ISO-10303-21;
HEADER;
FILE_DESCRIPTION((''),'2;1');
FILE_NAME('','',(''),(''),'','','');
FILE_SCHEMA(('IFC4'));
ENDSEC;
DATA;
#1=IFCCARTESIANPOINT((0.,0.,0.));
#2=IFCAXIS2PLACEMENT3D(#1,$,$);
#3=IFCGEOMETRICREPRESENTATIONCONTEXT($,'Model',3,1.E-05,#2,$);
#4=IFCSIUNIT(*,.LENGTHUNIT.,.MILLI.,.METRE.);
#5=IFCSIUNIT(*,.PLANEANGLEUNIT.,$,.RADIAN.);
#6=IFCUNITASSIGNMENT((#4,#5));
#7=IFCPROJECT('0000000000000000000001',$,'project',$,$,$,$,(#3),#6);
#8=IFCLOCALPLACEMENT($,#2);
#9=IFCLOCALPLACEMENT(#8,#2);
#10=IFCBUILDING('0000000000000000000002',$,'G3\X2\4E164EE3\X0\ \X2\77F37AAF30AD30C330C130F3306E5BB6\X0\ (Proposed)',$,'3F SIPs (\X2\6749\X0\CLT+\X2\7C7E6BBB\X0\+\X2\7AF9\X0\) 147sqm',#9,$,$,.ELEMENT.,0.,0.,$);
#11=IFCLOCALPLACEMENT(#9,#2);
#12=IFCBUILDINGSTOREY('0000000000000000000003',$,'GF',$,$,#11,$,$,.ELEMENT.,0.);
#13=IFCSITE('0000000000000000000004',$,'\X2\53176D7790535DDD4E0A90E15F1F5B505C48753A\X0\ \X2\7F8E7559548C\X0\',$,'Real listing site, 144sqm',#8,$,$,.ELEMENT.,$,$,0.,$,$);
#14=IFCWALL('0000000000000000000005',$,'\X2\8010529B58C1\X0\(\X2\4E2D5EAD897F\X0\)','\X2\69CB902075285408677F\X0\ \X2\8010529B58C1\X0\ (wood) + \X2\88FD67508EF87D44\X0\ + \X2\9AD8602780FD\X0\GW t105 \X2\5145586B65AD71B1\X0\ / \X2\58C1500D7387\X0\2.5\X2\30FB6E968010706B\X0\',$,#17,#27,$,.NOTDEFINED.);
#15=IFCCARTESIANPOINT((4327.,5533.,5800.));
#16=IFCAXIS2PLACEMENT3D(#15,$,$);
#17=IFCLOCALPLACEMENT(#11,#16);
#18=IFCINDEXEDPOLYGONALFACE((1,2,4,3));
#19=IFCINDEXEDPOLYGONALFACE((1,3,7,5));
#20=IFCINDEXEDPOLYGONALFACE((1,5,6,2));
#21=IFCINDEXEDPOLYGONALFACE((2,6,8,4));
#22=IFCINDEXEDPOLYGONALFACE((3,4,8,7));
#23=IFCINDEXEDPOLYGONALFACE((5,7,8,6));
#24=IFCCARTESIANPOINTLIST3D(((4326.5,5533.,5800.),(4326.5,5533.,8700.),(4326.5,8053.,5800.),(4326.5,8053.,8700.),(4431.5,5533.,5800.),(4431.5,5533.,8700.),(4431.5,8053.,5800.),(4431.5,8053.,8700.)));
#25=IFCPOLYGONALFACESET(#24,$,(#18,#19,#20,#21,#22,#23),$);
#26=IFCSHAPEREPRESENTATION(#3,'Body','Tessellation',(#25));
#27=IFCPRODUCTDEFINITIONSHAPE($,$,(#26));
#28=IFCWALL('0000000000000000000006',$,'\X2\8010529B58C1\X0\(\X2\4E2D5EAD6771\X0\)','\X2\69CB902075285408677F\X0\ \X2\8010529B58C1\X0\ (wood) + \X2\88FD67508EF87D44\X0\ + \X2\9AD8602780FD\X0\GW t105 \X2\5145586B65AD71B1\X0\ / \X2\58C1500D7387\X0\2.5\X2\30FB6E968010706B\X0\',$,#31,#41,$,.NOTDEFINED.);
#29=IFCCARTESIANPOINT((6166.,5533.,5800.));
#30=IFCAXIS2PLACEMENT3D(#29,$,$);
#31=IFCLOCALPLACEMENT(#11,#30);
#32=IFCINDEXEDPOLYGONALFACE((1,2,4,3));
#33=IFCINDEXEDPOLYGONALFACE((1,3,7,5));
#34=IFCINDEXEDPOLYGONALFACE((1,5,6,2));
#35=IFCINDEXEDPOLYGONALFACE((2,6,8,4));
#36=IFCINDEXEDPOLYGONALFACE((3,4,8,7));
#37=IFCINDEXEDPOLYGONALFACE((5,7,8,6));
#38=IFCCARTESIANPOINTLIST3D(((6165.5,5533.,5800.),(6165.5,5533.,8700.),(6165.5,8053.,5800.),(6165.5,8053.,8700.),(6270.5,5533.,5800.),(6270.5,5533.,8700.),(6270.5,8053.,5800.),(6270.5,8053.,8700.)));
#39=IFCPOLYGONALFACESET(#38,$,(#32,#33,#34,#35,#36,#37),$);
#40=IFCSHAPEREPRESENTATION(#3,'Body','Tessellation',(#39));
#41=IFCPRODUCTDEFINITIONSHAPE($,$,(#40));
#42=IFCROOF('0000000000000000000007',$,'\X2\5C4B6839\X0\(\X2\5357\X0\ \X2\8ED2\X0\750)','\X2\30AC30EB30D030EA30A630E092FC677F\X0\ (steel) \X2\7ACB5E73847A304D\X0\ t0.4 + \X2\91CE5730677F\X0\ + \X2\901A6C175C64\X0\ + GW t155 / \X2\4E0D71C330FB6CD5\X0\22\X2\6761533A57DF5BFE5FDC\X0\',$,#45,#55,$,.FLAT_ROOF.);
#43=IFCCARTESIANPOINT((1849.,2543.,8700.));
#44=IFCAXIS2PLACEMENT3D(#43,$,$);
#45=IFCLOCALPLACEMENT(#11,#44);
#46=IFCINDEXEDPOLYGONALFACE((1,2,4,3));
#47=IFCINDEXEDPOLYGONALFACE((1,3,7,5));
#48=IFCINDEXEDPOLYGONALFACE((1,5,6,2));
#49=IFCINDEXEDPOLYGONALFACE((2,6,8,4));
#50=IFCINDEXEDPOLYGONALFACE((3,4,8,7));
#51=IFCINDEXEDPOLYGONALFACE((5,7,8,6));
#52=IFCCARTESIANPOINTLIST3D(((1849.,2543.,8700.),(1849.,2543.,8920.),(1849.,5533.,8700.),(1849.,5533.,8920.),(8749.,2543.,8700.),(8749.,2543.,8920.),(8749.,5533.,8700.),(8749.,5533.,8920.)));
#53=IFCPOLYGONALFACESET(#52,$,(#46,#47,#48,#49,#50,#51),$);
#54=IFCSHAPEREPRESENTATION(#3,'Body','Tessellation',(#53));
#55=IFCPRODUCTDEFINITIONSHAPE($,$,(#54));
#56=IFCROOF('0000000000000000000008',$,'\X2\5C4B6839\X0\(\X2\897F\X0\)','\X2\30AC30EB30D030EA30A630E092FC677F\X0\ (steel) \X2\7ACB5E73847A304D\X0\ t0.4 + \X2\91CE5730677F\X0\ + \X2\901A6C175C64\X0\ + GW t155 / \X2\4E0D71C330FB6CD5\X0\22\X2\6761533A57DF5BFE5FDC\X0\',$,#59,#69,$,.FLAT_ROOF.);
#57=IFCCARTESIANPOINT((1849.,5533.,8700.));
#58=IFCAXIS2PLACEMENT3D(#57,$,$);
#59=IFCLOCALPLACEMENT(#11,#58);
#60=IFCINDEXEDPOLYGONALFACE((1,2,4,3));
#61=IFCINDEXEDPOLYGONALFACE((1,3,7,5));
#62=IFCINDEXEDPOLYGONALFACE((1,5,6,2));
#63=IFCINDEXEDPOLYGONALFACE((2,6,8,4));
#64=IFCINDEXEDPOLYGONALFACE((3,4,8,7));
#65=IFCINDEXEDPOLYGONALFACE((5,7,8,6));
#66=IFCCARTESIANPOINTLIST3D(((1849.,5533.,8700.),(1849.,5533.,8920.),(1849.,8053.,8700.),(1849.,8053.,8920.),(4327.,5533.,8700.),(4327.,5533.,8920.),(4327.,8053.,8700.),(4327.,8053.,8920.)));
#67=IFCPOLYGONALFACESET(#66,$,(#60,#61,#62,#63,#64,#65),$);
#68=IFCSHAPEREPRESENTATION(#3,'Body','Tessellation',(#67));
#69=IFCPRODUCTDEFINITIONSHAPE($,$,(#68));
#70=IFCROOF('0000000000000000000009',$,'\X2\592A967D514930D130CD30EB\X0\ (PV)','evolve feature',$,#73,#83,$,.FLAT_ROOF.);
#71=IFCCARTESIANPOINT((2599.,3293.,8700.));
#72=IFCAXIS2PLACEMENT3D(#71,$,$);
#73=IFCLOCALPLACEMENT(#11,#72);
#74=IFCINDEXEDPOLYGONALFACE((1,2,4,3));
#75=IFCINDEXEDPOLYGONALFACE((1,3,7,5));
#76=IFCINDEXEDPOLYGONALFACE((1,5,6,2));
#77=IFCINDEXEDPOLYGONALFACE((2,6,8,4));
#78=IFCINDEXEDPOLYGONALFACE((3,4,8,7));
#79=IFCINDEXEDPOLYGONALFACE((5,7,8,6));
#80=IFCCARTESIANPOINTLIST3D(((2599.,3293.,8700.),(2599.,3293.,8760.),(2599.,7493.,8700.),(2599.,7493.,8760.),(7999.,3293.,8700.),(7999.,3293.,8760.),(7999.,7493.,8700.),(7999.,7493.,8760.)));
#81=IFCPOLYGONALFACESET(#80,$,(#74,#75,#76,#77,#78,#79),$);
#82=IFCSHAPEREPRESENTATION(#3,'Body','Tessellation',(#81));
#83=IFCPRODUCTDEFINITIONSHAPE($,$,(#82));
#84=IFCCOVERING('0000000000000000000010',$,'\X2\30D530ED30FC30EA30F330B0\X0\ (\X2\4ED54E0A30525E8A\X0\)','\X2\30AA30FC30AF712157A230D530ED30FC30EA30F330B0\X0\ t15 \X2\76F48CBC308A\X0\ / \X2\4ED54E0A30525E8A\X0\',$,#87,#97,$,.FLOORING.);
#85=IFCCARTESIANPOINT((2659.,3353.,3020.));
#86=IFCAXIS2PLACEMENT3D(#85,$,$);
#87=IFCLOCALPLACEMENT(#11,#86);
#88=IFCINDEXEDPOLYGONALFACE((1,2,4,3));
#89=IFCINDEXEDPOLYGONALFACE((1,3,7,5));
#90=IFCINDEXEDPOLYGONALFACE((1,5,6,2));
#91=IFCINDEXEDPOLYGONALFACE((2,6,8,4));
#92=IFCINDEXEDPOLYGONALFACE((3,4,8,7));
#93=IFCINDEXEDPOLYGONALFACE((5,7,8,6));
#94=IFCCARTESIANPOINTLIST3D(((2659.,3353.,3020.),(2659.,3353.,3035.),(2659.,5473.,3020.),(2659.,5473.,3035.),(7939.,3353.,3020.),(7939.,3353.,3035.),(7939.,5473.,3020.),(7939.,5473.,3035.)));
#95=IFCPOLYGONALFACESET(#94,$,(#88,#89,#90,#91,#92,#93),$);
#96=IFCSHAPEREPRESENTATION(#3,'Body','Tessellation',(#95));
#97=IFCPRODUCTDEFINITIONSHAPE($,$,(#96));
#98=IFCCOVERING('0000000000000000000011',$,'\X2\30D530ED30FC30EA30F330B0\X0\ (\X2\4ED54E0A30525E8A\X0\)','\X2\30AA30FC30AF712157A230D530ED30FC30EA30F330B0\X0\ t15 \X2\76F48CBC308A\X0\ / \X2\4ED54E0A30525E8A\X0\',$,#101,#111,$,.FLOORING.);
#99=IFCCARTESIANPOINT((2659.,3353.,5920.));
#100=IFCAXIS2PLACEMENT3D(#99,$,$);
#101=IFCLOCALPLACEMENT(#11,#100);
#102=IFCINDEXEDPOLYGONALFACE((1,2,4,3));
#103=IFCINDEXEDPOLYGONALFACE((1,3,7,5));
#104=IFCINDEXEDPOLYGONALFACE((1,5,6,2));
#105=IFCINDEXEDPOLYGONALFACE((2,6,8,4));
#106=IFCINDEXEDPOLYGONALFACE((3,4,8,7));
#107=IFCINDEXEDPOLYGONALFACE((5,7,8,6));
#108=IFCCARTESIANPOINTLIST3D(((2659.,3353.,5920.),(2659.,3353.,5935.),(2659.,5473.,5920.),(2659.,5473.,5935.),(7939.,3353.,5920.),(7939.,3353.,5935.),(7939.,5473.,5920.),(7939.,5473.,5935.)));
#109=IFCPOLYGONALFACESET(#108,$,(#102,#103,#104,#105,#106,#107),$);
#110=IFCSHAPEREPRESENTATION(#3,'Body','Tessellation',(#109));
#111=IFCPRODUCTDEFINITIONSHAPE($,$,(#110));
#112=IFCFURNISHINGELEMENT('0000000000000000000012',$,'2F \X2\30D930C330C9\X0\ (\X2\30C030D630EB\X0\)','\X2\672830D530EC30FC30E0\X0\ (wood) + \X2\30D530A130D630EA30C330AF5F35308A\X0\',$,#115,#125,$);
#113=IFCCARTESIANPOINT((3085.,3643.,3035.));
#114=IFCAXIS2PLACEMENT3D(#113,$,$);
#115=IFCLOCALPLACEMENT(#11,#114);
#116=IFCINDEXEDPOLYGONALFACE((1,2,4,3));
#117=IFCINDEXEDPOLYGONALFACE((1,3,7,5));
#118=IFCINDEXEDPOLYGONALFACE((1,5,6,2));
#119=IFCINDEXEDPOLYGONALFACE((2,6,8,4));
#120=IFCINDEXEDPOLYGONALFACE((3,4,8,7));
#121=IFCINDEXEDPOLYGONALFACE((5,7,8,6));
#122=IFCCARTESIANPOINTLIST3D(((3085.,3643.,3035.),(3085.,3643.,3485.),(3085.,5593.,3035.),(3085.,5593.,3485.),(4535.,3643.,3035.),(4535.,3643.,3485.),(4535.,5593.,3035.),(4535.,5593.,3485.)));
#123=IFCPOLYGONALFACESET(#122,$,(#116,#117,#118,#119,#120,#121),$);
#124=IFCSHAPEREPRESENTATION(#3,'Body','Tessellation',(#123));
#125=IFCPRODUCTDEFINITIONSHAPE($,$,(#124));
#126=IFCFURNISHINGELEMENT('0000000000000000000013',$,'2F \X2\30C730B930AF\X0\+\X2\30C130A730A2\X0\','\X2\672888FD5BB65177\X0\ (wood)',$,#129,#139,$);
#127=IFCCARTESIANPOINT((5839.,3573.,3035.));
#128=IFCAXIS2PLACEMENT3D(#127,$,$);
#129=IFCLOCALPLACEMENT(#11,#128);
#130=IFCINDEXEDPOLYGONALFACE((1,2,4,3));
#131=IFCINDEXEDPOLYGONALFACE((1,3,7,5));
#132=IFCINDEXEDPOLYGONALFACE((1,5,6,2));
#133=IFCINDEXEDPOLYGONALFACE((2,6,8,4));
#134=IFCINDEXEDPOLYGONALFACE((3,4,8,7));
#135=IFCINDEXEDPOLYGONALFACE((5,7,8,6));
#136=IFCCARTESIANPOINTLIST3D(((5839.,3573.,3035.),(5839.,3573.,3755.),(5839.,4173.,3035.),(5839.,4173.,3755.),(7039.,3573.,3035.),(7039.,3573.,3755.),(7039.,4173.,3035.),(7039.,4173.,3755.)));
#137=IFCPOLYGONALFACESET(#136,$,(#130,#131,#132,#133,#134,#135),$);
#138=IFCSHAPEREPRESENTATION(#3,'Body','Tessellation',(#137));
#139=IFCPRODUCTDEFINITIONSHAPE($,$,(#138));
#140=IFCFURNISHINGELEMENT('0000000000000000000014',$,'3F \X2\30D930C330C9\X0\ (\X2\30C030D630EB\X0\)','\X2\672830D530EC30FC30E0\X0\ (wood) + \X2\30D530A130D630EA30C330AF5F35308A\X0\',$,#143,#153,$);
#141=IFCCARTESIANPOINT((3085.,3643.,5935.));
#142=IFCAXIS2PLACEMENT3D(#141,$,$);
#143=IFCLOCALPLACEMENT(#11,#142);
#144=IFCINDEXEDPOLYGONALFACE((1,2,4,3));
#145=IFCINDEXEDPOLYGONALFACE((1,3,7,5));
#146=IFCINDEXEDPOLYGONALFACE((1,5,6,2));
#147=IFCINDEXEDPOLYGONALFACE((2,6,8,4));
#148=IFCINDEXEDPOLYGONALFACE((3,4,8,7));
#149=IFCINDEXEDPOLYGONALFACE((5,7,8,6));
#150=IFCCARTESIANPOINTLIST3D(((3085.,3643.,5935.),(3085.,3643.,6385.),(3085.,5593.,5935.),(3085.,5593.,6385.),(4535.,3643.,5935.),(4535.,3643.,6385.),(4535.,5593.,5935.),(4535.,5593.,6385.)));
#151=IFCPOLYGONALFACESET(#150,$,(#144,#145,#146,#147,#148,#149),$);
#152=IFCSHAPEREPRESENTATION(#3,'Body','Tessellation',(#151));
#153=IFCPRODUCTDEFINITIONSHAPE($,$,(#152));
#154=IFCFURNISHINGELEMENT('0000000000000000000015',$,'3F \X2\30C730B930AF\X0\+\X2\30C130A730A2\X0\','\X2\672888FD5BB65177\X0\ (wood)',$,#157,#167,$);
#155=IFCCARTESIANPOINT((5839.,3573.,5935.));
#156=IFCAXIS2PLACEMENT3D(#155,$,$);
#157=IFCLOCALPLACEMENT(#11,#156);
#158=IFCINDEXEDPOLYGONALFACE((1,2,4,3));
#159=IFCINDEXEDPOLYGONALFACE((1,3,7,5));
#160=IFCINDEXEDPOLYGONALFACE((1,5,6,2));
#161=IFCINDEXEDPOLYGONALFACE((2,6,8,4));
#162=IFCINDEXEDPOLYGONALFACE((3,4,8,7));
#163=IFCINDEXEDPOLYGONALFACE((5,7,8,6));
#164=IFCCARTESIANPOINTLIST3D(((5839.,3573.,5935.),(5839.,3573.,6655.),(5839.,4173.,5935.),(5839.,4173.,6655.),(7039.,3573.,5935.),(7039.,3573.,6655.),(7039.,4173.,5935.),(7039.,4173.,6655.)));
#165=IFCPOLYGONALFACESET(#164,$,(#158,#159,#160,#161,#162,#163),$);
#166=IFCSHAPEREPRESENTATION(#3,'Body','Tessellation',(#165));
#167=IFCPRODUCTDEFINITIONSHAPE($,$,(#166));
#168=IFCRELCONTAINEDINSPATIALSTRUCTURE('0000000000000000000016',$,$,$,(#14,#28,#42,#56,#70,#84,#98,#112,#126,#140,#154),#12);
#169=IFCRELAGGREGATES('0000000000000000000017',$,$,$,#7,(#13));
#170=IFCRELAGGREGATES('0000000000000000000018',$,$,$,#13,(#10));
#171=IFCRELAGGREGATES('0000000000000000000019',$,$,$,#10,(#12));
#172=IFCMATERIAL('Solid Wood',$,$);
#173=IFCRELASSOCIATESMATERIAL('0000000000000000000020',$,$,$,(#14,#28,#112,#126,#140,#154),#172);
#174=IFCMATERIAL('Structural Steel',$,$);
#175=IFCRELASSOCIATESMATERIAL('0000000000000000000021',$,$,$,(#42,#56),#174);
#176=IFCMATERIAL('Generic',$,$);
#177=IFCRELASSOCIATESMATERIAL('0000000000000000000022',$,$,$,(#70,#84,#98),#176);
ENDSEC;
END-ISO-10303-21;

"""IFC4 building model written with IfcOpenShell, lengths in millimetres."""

from ifc_helpers import new_model, si_unit, frame, frame_2d, origin, place, context, project, spatial, rectangle, extrude, material, element, save


model = new_model("IFC4")

# Units and contexts
model_context = context("Model", 3, precision=1e-05, world=origin())
ifc_project = project(units=[si_unit("LENGTHUNIT", "METRE", prefix="MILLI"), si_unit("PLANEANGLEUNIT", "RADIAN")], contexts=[model_context])

# Site, building, storey
site_placement = place(None, origin())
site = spatial("IfcSite", under=ifc_project, at=site_placement, Name="北海道川上郡弟子屈町 美留和", ObjectType="Real listing site, 144sqm", CompositionType="ELEMENT", RefElevation=0.0)
building_placement = place(site_placement, origin())
building = spatial("IfcBuilding", under=site, at=building_placement, Name="G3世代 石窯キッチンの家 (Proposed)", ObjectType="3F SIPs (杉CLT+籾殻+竹) 147sqm", CompositionType="ELEMENT", ElevationOfRefHeight=0.0, ElevationOfTerrain=0.0)
storey_placement = place(building_placement, origin())
storey = spatial("IfcBuildingStorey", under=building, at=storey_placement, Name="GF", CompositionType="ELEMENT", Elevation=0.0)

# Shared definitions
ifc_material_1 = material(Name="Solid Wood")

# Walls
wall_1_placement = place(storey_placement, frame((4327.0, 5533.0, 5800.0)))
element("IfcWall", 1, at=wall_1_placement, inside=storey, material=ifc_material_1, Name="耐力壁(中庭西)", Description="構造用合板 耐力壁 (wood) + 製材軸組 + 高性能GW t105 充填断熱 / 壁倍率2.5・準耐火", PredefinedType="NOTDEFINED", context=model_context, shape_type="SweptSolid", body=[
    extrude(rectangle(XDim=105.0, YDim=2520.0, at=frame_2d((52.0, 1260.0))), frame((4327.0, 5533.0, 5800.0)), (0.0, 0.0, 1.0), 2900.0),
])
wall_2_placement = place(storey_placement, frame((6166.0, 5533.0, 5800.0)))
element("IfcWall", 2, at=wall_2_placement, inside=storey, material=ifc_material_1, Name="耐力壁(中庭東)", Description="構造用合板 耐力壁 (wood) + 製材軸組 + 高性能GW t105 充填断熱 / 壁倍率2.5・準耐火", PredefinedType="NOTDEFINED", context=model_context, shape_type="SweptSolid", body=[
    extrude(rectangle(XDim=105.0, YDim=2520.0, at=frame_2d((52.0, 1260.0))), frame((6166.0, 5533.0, 5800.0)), (0.0, 0.0, 1.0), 2900.0),
])

# Roofs
ifc_material_2 = material(Name="Structural Steel")
roof_1_placement = place(storey_placement, frame((1849.0, 2543.0, 8700.0)))
element("IfcRoof", 3, at=roof_1_placement, inside=storey, material=ifc_material_2, Name="屋根(南 軒750)", Description="ガルバリウム鋼板 (steel) 立平葺き t0.4 + 野地板 + 通気層 + GW t155 / 不燃・法22条区域対応", PredefinedType="FLAT_ROOF", context=model_context, shape_type="SweptSolid", body=[
    extrude(rectangle(XDim=6900.0, YDim=2990.0, at=frame_2d((3450.0, 1495.0))), frame((1849.0, 2543.0, 8700.0)), (0.0, 0.0, 1.0), 220.0),
])
roof_2_placement = place(storey_placement, frame((1849.0, 5533.0, 8700.0)))
element("IfcRoof", 4, at=roof_2_placement, inside=storey, material=ifc_material_2, Name="屋根(西)", Description="ガルバリウム鋼板 (steel) 立平葺き t0.4 + 野地板 + 通気層 + GW t155 / 不燃・法22条区域対応", PredefinedType="FLAT_ROOF", context=model_context, shape_type="SweptSolid", body=[
    extrude(rectangle(XDim=2478.0, YDim=2520.0, at=frame_2d((1239.0, 1260.0))), frame((1849.0, 5533.0, 8700.0)), (0.0, 0.0, 1.0), 220.0),
])
ifc_material_3 = material(Name="Generic")
roof_3_placement = place(storey_placement, frame((2599.0, 3293.0, 8700.0)))
element("IfcRoof", 5, at=roof_3_placement, inside=storey, material=ifc_material_3, Name="太陽光パネル (PV)", Description="evolve feature", PredefinedType="FLAT_ROOF", context=model_context, shape_type="SweptSolid", body=[
    extrude(rectangle(XDim=5400.0, YDim=4200.0, at=frame_2d((2700.0, 2100.0))), frame((2599.0, 3293.0, 8700.0)), (0.0, 0.0, 1.0), 60.0),
])

# Coverings
covering_1_placement = place(storey_placement, frame((2659.0, 3353.0, 3020.0)))
element("IfcCovering", 6, at=covering_1_placement, inside=storey, material=ifc_material_3, Name="フローリング (仕上げ床)", Description="オーク無垢フローリング t15 直貼り / 仕上げ床", PredefinedType="FLOORING", context=model_context, shape_type="SweptSolid", body=[
    extrude(rectangle(XDim=5280.0, YDim=2120.0, at=frame_2d((2640.0, 1060.0))), frame((2659.0, 3353.0, 3020.0)), (0.0, 0.0, 1.0), 15.0),
])
covering_2_placement = place(storey_placement, frame((2659.0, 3353.0, 5920.0)))
element("IfcCovering", 7, at=covering_2_placement, inside=storey, material=ifc_material_3, Name="フローリング (仕上げ床)", Description="オーク無垢フローリング t15 直貼り / 仕上げ床", PredefinedType="FLOORING", context=model_context, shape_type="SweptSolid", body=[
    extrude(rectangle(XDim=5280.0, YDim=2120.0, at=frame_2d((2640.0, 1060.0))), frame((2659.0, 3353.0, 5920.0)), (0.0, 0.0, 1.0), 15.0),
])

# Furnishing elements
furnishing_1_placement = place(storey_placement, frame((3085.0, 3643.0, 3035.0)))
element("IfcFurnishingElement", 8, at=furnishing_1_placement, inside=storey, material=ifc_material_1, Name="2F ベッド (ダブル)", Description="木フレーム (wood) + ファブリック張り", context=model_context, shape_type="SweptSolid", body=[
    extrude(rectangle(XDim=1450.0, YDim=1950.0, at=frame_2d((725.0, 975.0))), frame((3085.0, 3643.0, 3035.0)), (0.0, 0.0, 1.0), 450.0),
])
furnishing_2_placement = place(storey_placement, frame((5839.0, 3573.0, 3035.0)))
element("IfcFurnishingElement", 9, at=furnishing_2_placement, inside=storey, material=ifc_material_1, Name="2F デスク+チェア", Description="木製家具 (wood)", context=model_context, shape_type="SweptSolid", body=[
    extrude(rectangle(XDim=1200.0, YDim=600.0, at=frame_2d((600.0, 300.0))), frame((5839.0, 3573.0, 3035.0)), (0.0, 0.0, 1.0), 720.0),
])
furnishing_3_placement = place(storey_placement, frame((3085.0, 3643.0, 5935.0)))
element("IfcFurnishingElement", 10, at=furnishing_3_placement, inside=storey, material=ifc_material_1, Name="3F ベッド (ダブル)", Description="木フレーム (wood) + ファブリック張り", context=model_context, shape_type="SweptSolid", body=[
    extrude(rectangle(XDim=1450.0, YDim=1950.0, at=frame_2d((725.0, 975.0))), frame((3085.0, 3643.0, 5935.0)), (0.0, 0.0, 1.0), 450.0),
])
furnishing_4_placement = place(storey_placement, frame((5839.0, 3573.0, 5935.0)))
element("IfcFurnishingElement", 11, at=furnishing_4_placement, inside=storey, material=ifc_material_1, Name="3F デスク+チェア", Description="木製家具 (wood)", context=model_context, shape_type="SweptSolid", body=[
    extrude(rectangle(XDim=1200.0, YDim=600.0, at=frame_2d((600.0, 300.0))), frame((5839.0, 3573.0, 5935.0)), (0.0, 0.0, 1.0), 720.0),
])

save(model, "model.ifc")
